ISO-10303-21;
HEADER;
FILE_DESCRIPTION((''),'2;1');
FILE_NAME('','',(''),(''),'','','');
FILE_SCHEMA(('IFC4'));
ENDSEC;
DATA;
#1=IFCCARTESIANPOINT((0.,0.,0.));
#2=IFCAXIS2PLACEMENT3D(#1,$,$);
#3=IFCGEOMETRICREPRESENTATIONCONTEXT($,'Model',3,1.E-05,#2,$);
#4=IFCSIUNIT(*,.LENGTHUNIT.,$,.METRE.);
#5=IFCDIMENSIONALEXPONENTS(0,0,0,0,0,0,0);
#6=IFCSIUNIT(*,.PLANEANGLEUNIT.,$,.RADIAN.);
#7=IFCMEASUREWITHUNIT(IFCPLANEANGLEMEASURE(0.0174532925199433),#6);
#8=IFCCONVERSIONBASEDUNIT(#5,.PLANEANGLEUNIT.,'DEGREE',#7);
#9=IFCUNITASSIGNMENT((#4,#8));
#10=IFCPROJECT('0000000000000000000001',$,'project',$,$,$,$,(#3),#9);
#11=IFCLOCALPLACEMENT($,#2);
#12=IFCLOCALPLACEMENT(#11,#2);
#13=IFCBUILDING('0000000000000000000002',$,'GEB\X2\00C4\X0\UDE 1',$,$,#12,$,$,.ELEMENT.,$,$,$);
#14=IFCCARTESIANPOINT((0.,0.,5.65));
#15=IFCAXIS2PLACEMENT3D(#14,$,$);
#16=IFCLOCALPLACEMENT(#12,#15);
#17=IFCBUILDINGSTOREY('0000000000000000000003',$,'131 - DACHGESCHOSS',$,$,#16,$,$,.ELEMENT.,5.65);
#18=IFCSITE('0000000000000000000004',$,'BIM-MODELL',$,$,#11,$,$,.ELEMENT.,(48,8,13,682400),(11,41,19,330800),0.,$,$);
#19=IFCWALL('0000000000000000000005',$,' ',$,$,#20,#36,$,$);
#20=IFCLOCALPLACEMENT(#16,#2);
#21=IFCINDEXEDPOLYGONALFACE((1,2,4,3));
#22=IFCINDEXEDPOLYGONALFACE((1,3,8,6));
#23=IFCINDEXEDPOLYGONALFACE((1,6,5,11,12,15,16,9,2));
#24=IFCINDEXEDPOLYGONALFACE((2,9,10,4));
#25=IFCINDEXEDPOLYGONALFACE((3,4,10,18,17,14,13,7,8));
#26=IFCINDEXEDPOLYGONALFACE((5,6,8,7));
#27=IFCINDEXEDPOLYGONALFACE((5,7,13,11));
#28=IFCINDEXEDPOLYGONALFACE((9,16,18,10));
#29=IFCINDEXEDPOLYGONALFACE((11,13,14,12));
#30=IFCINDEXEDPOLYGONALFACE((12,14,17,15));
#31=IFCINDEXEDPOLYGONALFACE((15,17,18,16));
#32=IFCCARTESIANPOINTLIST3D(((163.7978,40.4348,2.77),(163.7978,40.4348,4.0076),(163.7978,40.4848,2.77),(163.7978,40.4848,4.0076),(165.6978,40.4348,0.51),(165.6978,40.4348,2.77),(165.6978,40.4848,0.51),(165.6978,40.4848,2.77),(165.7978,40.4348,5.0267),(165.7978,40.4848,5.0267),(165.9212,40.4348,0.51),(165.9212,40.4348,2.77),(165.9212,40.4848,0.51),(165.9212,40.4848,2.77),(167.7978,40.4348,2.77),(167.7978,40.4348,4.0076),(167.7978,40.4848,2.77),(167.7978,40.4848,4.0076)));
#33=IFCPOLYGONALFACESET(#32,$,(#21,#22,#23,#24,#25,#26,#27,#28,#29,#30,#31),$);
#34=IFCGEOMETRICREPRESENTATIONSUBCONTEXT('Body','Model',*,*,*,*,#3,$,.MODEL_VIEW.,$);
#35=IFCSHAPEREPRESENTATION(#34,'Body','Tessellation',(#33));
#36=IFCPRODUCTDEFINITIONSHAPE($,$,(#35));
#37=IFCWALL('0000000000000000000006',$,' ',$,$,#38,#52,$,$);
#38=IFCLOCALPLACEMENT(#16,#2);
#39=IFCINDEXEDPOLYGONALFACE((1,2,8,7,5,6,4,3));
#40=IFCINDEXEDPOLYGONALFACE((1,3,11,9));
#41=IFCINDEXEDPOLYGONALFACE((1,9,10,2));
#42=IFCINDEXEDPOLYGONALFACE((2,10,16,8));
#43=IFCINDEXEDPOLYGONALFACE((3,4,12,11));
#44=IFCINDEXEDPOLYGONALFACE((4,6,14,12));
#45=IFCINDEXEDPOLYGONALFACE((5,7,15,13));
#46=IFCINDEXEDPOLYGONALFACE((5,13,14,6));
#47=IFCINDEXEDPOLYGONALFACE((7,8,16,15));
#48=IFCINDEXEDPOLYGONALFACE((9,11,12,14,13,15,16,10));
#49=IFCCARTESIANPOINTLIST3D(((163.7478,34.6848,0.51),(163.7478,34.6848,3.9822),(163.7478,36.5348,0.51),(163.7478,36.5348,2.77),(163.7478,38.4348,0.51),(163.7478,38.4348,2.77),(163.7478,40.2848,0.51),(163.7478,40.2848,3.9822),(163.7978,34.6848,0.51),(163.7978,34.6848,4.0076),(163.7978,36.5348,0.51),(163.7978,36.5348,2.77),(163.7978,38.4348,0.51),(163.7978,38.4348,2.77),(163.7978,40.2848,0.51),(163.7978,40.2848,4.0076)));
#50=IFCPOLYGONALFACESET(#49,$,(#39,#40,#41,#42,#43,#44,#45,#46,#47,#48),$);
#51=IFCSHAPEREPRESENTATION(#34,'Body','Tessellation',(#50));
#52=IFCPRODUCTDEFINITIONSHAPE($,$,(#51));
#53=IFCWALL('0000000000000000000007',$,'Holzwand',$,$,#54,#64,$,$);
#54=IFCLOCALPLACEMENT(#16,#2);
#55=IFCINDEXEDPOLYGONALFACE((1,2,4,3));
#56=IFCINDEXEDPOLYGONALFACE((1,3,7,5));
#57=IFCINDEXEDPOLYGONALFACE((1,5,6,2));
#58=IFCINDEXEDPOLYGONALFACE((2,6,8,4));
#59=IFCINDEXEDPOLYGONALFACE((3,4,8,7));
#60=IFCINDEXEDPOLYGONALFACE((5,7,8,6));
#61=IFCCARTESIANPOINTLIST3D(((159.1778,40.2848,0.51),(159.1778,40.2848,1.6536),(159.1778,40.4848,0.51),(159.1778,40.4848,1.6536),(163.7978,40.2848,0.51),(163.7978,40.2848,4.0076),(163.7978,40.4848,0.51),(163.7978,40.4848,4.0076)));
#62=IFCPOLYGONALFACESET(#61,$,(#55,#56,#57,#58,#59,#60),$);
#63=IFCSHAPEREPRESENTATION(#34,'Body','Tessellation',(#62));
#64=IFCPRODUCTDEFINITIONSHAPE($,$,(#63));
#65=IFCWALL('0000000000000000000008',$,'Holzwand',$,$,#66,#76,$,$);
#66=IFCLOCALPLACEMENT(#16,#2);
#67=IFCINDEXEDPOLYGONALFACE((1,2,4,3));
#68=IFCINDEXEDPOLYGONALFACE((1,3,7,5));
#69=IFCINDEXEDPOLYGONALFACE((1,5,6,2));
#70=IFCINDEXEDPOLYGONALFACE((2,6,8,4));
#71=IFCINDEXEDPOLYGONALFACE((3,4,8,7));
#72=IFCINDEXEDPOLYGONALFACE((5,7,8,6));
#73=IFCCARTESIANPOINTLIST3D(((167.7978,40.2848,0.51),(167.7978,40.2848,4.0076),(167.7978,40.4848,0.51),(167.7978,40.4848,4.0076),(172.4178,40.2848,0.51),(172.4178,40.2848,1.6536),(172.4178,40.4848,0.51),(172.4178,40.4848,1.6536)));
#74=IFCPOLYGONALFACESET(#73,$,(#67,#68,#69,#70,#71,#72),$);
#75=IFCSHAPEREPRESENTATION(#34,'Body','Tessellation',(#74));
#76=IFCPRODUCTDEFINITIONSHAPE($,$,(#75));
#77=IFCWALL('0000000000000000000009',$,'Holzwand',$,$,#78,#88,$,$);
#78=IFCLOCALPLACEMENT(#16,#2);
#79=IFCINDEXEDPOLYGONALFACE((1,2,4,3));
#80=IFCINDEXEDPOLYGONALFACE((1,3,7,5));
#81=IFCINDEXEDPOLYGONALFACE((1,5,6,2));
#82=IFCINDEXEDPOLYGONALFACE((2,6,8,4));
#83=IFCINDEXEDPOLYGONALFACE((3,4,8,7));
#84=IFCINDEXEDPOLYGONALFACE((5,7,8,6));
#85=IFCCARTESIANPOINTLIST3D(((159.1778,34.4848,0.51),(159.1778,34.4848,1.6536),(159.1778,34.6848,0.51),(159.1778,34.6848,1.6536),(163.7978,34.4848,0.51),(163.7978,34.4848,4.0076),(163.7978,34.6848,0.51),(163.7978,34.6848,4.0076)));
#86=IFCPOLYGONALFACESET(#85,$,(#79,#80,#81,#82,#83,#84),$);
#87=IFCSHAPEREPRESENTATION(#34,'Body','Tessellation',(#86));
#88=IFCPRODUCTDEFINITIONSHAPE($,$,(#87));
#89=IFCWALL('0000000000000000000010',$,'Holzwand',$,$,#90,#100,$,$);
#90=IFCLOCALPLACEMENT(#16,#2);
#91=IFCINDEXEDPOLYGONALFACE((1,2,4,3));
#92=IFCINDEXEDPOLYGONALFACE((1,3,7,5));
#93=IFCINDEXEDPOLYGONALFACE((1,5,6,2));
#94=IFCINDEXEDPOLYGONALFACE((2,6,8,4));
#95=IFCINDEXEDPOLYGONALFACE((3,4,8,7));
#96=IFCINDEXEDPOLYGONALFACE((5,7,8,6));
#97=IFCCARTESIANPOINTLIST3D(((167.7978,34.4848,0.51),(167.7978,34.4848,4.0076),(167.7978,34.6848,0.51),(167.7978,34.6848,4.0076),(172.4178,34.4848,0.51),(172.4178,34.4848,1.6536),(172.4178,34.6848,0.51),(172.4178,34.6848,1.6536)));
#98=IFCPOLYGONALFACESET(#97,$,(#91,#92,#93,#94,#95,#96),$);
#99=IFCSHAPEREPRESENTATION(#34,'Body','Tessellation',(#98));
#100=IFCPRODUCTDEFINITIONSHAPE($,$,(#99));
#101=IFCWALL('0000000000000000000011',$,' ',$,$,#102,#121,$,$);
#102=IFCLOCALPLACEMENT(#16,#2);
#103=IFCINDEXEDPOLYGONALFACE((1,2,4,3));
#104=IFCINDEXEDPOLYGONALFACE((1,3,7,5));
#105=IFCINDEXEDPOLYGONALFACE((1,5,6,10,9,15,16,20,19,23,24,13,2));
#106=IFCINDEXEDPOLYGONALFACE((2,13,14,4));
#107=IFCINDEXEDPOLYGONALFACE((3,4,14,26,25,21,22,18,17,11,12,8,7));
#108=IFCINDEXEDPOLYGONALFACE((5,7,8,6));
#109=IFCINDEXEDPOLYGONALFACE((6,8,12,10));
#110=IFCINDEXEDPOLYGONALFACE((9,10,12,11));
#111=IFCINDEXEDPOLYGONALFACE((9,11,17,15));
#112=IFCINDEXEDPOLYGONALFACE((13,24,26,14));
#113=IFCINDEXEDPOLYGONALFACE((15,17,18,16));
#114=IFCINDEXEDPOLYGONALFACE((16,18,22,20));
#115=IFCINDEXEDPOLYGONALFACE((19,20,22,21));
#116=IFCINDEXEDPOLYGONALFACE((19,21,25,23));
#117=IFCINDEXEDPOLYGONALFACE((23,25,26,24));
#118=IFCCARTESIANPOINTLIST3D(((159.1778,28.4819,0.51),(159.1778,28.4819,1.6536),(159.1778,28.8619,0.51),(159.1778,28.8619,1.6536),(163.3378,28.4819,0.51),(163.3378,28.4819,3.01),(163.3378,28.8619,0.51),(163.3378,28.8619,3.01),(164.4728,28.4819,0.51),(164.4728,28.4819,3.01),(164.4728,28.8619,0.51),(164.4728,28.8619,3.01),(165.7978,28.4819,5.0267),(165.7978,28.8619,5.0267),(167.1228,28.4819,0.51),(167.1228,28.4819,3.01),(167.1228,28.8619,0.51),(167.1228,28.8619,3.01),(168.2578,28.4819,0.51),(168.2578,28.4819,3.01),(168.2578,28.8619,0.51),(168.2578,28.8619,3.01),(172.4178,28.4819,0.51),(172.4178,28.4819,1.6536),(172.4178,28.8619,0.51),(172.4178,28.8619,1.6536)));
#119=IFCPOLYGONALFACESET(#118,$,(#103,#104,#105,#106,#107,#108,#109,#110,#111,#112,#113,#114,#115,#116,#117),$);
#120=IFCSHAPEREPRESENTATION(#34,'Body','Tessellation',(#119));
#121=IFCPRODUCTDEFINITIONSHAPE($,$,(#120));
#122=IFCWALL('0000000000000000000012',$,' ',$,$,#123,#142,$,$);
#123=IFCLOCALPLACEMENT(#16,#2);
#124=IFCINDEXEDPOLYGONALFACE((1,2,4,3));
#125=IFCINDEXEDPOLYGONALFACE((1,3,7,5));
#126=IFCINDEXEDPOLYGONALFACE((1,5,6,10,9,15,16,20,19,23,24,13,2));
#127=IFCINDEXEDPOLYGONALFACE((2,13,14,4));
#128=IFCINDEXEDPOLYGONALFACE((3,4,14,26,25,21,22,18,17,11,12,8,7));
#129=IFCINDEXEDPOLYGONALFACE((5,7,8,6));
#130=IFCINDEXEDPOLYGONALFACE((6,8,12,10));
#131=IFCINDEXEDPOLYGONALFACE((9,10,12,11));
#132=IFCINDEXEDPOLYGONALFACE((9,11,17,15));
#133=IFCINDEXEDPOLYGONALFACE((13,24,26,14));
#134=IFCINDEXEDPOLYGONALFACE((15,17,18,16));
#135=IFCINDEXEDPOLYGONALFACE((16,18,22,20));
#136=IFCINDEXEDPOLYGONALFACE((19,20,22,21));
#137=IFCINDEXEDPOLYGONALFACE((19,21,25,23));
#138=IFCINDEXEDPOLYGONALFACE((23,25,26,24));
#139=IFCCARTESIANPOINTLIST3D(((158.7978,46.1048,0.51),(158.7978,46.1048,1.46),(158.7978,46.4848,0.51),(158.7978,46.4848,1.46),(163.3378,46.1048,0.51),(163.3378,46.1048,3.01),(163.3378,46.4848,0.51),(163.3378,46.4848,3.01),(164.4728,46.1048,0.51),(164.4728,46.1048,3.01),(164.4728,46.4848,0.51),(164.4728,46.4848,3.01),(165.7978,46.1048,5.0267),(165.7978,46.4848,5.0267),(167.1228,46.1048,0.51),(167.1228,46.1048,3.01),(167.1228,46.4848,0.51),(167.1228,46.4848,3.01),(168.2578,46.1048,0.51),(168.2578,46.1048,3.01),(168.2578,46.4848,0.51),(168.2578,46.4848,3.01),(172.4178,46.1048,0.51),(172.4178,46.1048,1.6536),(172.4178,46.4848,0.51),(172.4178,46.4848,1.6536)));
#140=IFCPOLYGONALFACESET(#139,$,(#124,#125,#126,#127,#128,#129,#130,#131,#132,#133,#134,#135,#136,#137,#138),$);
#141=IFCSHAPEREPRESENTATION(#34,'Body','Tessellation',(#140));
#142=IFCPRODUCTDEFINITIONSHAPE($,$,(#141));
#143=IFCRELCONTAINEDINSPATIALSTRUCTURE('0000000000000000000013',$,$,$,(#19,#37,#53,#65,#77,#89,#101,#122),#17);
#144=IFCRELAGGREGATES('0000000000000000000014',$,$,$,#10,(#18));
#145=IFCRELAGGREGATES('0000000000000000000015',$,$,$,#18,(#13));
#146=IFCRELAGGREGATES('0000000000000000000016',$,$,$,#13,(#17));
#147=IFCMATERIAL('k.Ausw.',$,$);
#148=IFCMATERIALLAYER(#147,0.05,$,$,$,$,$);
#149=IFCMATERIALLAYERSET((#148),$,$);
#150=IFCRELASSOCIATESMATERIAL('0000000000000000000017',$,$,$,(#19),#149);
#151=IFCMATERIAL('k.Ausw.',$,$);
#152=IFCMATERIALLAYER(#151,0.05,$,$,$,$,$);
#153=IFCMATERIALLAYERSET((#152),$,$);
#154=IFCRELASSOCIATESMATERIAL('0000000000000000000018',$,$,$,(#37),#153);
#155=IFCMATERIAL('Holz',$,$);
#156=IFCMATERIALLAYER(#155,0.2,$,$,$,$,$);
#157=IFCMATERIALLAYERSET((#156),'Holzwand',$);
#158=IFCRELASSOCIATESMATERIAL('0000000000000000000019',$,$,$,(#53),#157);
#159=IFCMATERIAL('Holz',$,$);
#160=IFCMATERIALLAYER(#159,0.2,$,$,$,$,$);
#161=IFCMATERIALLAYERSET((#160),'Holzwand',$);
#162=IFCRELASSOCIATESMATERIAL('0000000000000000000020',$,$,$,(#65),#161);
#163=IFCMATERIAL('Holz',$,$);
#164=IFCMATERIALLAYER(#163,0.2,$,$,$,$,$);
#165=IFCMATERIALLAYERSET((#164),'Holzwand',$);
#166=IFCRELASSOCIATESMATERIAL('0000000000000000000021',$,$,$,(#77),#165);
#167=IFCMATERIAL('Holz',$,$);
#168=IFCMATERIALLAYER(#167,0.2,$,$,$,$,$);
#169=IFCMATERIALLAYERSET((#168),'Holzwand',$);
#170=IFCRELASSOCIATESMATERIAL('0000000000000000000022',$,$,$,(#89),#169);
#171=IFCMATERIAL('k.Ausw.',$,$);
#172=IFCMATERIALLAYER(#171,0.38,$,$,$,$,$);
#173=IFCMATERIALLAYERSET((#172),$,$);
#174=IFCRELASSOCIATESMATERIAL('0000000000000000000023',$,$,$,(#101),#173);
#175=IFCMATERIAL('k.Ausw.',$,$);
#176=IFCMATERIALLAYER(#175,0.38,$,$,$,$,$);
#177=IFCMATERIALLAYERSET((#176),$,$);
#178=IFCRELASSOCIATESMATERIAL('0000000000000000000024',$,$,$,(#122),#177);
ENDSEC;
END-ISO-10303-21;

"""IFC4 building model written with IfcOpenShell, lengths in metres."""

from ifc_helpers import new_model, entity, si_unit, converted_unit, frame, frame_2d, origin, origin_with_axes, place, context, subcontext, project, spatial, polyline, rectangle, outline, extrude, clip, halfspace, bounded_halfspace, material, layer, layer_set, layer_usage, element, save


model = new_model("IFC4")

# Units and contexts
model_context = context("Model", 3, precision=1e-05, world=origin())
body_context = subcontext(model_context, "Body", "Model", "MODEL_VIEW")
ifc_project = project(units=[si_unit("LENGTHUNIT", "METRE"), converted_unit("PLANEANGLEUNIT", "DEGREE", entity("IfcPlaneAngleMeasure", 0.0174532925199433), si_unit("PLANEANGLEUNIT", "RADIAN"), dimensions=[0, 0, 0, 0, 0, 0, 0])], contexts=[model_context])

# Site, building, storey
site_placement = place(None, origin())
site = spatial("IfcSite", under=ifc_project, at=site_placement, Name="BIM-MODELL", CompositionType="ELEMENT", RefLatitude=(48, 8, 13, 682400), RefLongitude=(11, 41, 19, 330800), RefElevation=0.0)
building_placement = place(site_placement, origin())
building = spatial("IfcBuilding", under=site, at=building_placement, Name="GEBÄUDE 1", CompositionType="ELEMENT")
storey_placement = place(building_placement, frame((0.0, 0.0, 5.65)))
storey = spatial("IfcBuildingStorey", under=building, at=storey_placement, Name="131 - DACHGESCHOSS", CompositionType="ELEMENT", Elevation=5.65)

# Wall, openings
ifc_material_1 = material(Name="k.Ausw.")
ifc_layer_1 = layer(ifc_material_1, 0.05)
ifc_layer_set_1 = layer_set([ifc_layer_1])
ifc_layer_usage_1 = layer_usage(ifc_layer_set_1, "AXIS2", "POSITIVE", 0.0)
wall_1_placement = place(storey_placement, frame((167.7978, 40.4848, 0.51), z_axis=(0.0, 0.0, 1.0), x_axis=(-1.0, 0.0, 0.0)))
wall_1 = element("IfcWall", 1, at=wall_1_placement, inside=storey, material=ifc_layer_usage_1, Name=" ", context=body_context, shape_type="Clipping", body=[
    clip(clip(extrude(rectangle(XDim=4.0, YDim=0.05, at=frame_2d((2.0, 0.025), x_axis=(1.0, 0.0))), origin_with_axes(), (0.0, 0.0, 1.0), 4.5167), bounded_halfspace(frame((1.0, 0.025, 4.0072), z_axis=(0.45399, 0.0, -0.891007), x_axis=(0.891007, 0.0, 0.45399)), True, origin_with_axes(), polyline([(0.0, 0.0), (2.0, 0.0), (2.0, 0.05), (0.0, 0.05), (0.0, 0.0)]))), bounded_halfspace(frame((3.0, 0.025, 4.0072), z_axis=(-0.45399, 0.0, -0.891007), x_axis=(-0.891007, 0.0, 0.45399)), True, origin_with_axes(), polyline([(4.0, 0.05), (2.0, 0.05), (2.0, 0.0), (4.0, 0.0), (4.0, 0.05)]))),
])
opening_1_placement = place(wall_1_placement, frame((2.1, 0.0, 0.0), z_axis=(0.0, 1.0, 0.0), x_axis=(0.0, 0.0, 1.0)))
element("IfcOpeningElement", 2, at=opening_1_placement, cuts=wall_1, ObjectType="Opening", context=body_context, shape_type="SweptSolid", body=[
    extrude(outline(polyline([(0.0, 1.9), (2.26, 1.9), (2.26, 0.0), (0.0, 0.0), (0.0, 1.9)])), origin_with_axes(), (0.0, 0.0, 1.0), 0.05),
])
opening_2_placement = place(wall_1_placement, frame((0.0, 0.0, 0.0), z_axis=(0.0, 1.0, 0.0), x_axis=(0.0, 0.0, 1.0)))
element("IfcOpeningElement", 3, at=opening_2_placement, cuts=wall_1, ObjectType="Opening", context=body_context, shape_type="SweptSolid", body=[
    extrude(outline(polyline([(0.0, 1.8765), (2.26, 1.8765), (2.26, 0.0), (0.0, 0.0), (0.0, 1.8765)])), origin_with_axes(), (0.0, 0.0, 1.0), 0.05),
])

# Wall, opening
ifc_material_2 = material(Name="k.Ausw.")
ifc_layer_2 = layer(ifc_material_2, 0.05)
ifc_layer_set_2 = layer_set([ifc_layer_2])
ifc_layer_usage_2 = layer_usage(ifc_layer_set_2, "AXIS2", "POSITIVE", 0.0)
wall_2_placement = place(storey_placement, frame((163.7478, 40.2848, 0.51), z_axis=(0.0, 0.0, 1.0), x_axis=(0.0, -1.0, 0.0)))
wall_2 = element("IfcWall", 4, at=wall_2_placement, inside=storey, material=ifc_layer_usage_2, Name=" ", context=body_context, shape_type="Clipping", body=[
    clip(extrude(rectangle(XDim=5.6, YDim=0.05, at=frame_2d((2.8, 0.025), x_axis=(1.0, 0.0))), origin_with_axes(), (0.0, 0.0, 1.0), 3.4976), halfspace(frame((2.8, 0.025, 3.4849), z_axis=(0.0, 0.45399, -0.891007), x_axis=(1.0, 0.0, 0.0)), True)),
])
opening_3_placement = place(wall_2_placement, frame((1.85, 0.0, 0.0), z_axis=(0.0, 1.0, 0.0), x_axis=(0.0, 0.0, 1.0)))
element("IfcOpeningElement", 5, at=opening_3_placement, cuts=wall_2, ObjectType="Opening", context=body_context, shape_type="SweptSolid", body=[
    extrude(outline(polyline([(0.0, 1.9), (2.26, 1.9), (2.26, 0.0), (0.0, 0.0), (0.0, 1.9)])), origin_with_axes(), (0.0, 0.0, 1.0), 0.05),
])

# Walls
ifc_material_3 = material(Name="Holz")
ifc_layer_3 = layer(ifc_material_3, 0.2)
ifc_layer_set_3 = layer_set([ifc_layer_3], Name="Holzwand")
ifc_layer_usage_3 = layer_usage(ifc_layer_set_3, "AXIS2", "POSITIVE", 0.0)
wall_3_placement = place(storey_placement, frame((163.7978, 40.4848, 0.51), z_axis=(0.0, 0.0, 1.0), x_axis=(-1.0, 0.0, 0.0)))
element("IfcWall", 6, at=wall_3_placement, inside=storey, material=ifc_layer_usage_3, Name="Holzwand", context=body_context, shape_type="Clipping", body=[
    clip(extrude(rectangle(XDim=4.62, YDim=0.2, at=frame_2d((2.31, 0.1), x_axis=(1.0, 0.0))), origin_with_axes(), (0.0, 0.0, 1.0), 3.4976), halfspace(frame((2.31, 0.1, 2.3206), z_axis=(-0.45399, 0.0, -0.891007), x_axis=(0.891007, 0.0, -0.45399)), True)),
])
ifc_material_4 = material(Name="Holz")
ifc_layer_4 = layer(ifc_material_4, 0.2)
ifc_layer_set_4 = layer_set([ifc_layer_4], Name="Holzwand")
ifc_layer_usage_4 = layer_usage(ifc_layer_set_4, "AXIS2", "POSITIVE", 0.0)
wall_4_placement = place(storey_placement, frame((172.4178, 40.4848, 0.51), z_axis=(0.0, 0.0, 1.0), x_axis=(-1.0, 0.0, 0.0)))
element("IfcWall", 7, at=wall_4_placement, inside=storey, material=ifc_layer_usage_4, Name="Holzwand", context=body_context, shape_type="Clipping", body=[
    clip(extrude(rectangle(XDim=4.62, YDim=0.2, at=frame_2d((2.31, 0.1), x_axis=(1.0, 0.0))), origin_with_axes(), (0.0, 0.0, 1.0), 3.4976), halfspace(frame((2.31, 0.1, 2.3206), z_axis=(0.45399, 0.0, -0.891007), x_axis=(0.891007, 0.0, 0.45399)), True)),
])
ifc_material_5 = material(Name="Holz")
ifc_layer_5 = layer(ifc_material_5, 0.2)
ifc_layer_set_5 = layer_set([ifc_layer_5], Name="Holzwand")
ifc_layer_usage_5 = layer_usage(ifc_layer_set_5, "AXIS2", "POSITIVE", 0.0)
wall_5_placement = place(storey_placement, frame((159.1778, 34.4848, 0.51)))
element("IfcWall", 8, at=wall_5_placement, inside=storey, material=ifc_layer_usage_5, Name="Holzwand", context=body_context, shape_type="Clipping", body=[
    clip(extrude(rectangle(XDim=4.62, YDim=0.2, at=frame_2d((2.31, 0.1), x_axis=(1.0, 0.0))), origin_with_axes(), (0.0, 0.0, 1.0), 3.4976), halfspace(frame((2.31, 0.1, 2.3206), z_axis=(0.45399, 0.0, -0.891007), x_axis=(0.891007, 0.0, 0.45399)), True)),
])
ifc_material_6 = material(Name="Holz")
ifc_layer_6 = layer(ifc_material_6, 0.2)
ifc_layer_set_6 = layer_set([ifc_layer_6], Name="Holzwand")
ifc_layer_usage_6 = layer_usage(ifc_layer_set_6, "AXIS2", "POSITIVE", 0.0)
wall_6_placement = place(storey_placement, frame((167.7978, 34.4848, 0.51)))
element("IfcWall", 9, at=wall_6_placement, inside=storey, material=ifc_layer_usage_6, Name="Holzwand", context=body_context, shape_type="Clipping", body=[
    clip(extrude(rectangle(XDim=4.62, YDim=0.2, at=frame_2d((2.31, 0.1), x_axis=(1.0, 0.0))), origin_with_axes(), (0.0, 0.0, 1.0), 3.4976), halfspace(frame((2.31, 0.1, 2.3206), z_axis=(-0.45399, 0.0, -0.891007), x_axis=(0.891007, 0.0, -0.45399)), True)),
])

# Walls, openings
ifc_material_7 = material(Name="k.Ausw.")
ifc_layer_7 = layer(ifc_material_7, 0.38)
ifc_layer_set_7 = layer_set([ifc_layer_7])
ifc_layer_usage_7 = layer_usage(ifc_layer_set_7, "AXIS2", "POSITIVE", 0.0)
wall_7_placement = place(storey_placement, frame((159.1778, 28.4819, 0.51), z_axis=(0.0, 0.0, 1.0), x_axis=(1.0, 0.0, 0.0)))
wall_7 = element("IfcWall", 10, at=wall_7_placement, inside=storey, material=ifc_layer_usage_7, Name=" ", context=body_context, shape_type="Clipping", body=[
    clip(clip(extrude(rectangle(XDim=13.24, YDim=0.38, at=frame_2d((6.62, 0.19), x_axis=(1.0, 0.0))), origin_with_axes(), (0.0, 0.0, 1.0), 4.5167), bounded_halfspace(frame((9.93, 0.19, 2.8301), z_axis=(-0.45399, 0.0, -0.891007), x_axis=(-0.891007, 0.0, 0.45399)), True, origin_with_axes(), polyline([(13.24, 0.38), (6.62, 0.38), (6.62, 0.0), (13.24, 0.0), (13.24, 0.38)]))), bounded_halfspace(frame((3.31, 0.19, 2.8301), z_axis=(0.45399, 0.0, -0.891007), x_axis=(0.0, -1.0, 0.0)), True, origin_with_axes(), polyline([(0.0, 0.38), (0.0, 0.0), (6.62, 0.0), (6.62, 0.38), (0.0, 0.38)]))),
])
opening_4_placement = place(wall_7_placement, frame((9.08, 0.38, 0.0), z_axis=(0.0, -1.0, 0.0), x_axis=(0.0, 0.0, 1.0)))
element("IfcOpeningElement", 11, at=opening_4_placement, cuts=wall_7, ObjectType="Opening", context=body_context, shape_type="SweptSolid", body=[
    extrude(outline(polyline([(0.0, 1.135), (2.5, 1.135), (2.5, 0.0), (0.0, 0.0), (0.0, 1.135)])), origin_with_axes(), (0.0, 0.0, 1.0), 0.38),
])
opening_5_placement = place(wall_7_placement, frame((5.295, 0.38, 0.0), z_axis=(0.0, -1.0, 0.0), x_axis=(0.0, 0.0, 1.0)))
element("IfcOpeningElement", 12, at=opening_5_placement, cuts=wall_7, ObjectType="Opening", context=body_context, shape_type="SweptSolid", body=[
    extrude(outline(polyline([(0.0, 1.135), (2.5, 1.135), (2.5, 0.0), (0.0, 0.0), (0.0, 1.135)])), origin_with_axes(), (0.0, 0.0, 1.0), 0.38),
])
ifc_material_8 = material(Name="k.Ausw.")
ifc_layer_8 = layer(ifc_material_8, 0.38)
ifc_layer_set_8 = layer_set([ifc_layer_8])
ifc_layer_usage_8 = layer_usage(ifc_layer_set_8, "AXIS2", "POSITIVE", 0.0)
wall_8_placement = place(storey_placement, frame((172.4178, 46.4848, 0.51), z_axis=(0.0, 0.0, 1.0), x_axis=(-1.0, 0.0, 0.0)))
wall_8 = element("IfcWall", 13, at=wall_8_placement, inside=storey, material=ifc_layer_usage_8, Name=" ", context=body_context, shape_type="Clipping", body=[
    clip(clip(extrude(rectangle(XDim=13.62, YDim=0.38, at=frame_2d((6.81, 0.19), x_axis=(1.0, 0.0))), origin_with_axes(), (0.0, 0.0, 1.0), 4.5167), bounded_halfspace(frame((3.31, 0.19, 2.8301), z_axis=(0.45399, 0.0, -0.891007), x_axis=(0.0, -1.0, 0.0)), True, origin_with_axes(), polyline([(0.0, 0.38), (0.0, 0.0), (6.62, 0.0), (6.62, 0.38), (0.0, 0.38)]))), bounded_halfspace(frame((10.12, 0.19, 2.7333), z_axis=(-0.45399, 0.0, -0.891007), x_axis=(0.891007, 0.0, -0.45399)), True, origin_with_axes(), polyline([(6.62, 0.0), (13.62, 0.0), (13.62, 0.38), (6.62, 0.38), (6.62, 0.0)]))),
])
opening_6_placement = place(wall_8_placement, frame((5.295, 0.38, 0.0), z_axis=(0.0, -1.0, 0.0), x_axis=(0.0, 0.0, 1.0)))
element("IfcOpeningElement", 14, at=opening_6_placement, cuts=wall_8, ObjectType="Opening", context=body_context, shape_type="SweptSolid", body=[
    extrude(outline(polyline([(0.0, 1.135), (2.5, 1.135), (2.5, 0.0), (0.0, 0.0), (0.0, 1.135)])), origin_with_axes(), (0.0, 0.0, 1.0), 0.38),
])
opening_7_placement = place(wall_8_placement, frame((9.08, 0.38, 0.0), z_axis=(0.0, -1.0, 0.0), x_axis=(0.0, 0.0, 1.0)))
element("IfcOpeningElement", 15, at=opening_7_placement, cuts=wall_8, ObjectType="Opening", context=body_context, shape_type="SweptSolid", body=[
    extrude(outline(polyline([(0.0, 1.135), (2.5, 1.135), (2.5, 0.0), (0.0, 0.0), (0.0, 1.135)])), origin_with_axes(), (0.0, 0.0, 1.0), 0.38),
])

save(model, "model.ifc")
